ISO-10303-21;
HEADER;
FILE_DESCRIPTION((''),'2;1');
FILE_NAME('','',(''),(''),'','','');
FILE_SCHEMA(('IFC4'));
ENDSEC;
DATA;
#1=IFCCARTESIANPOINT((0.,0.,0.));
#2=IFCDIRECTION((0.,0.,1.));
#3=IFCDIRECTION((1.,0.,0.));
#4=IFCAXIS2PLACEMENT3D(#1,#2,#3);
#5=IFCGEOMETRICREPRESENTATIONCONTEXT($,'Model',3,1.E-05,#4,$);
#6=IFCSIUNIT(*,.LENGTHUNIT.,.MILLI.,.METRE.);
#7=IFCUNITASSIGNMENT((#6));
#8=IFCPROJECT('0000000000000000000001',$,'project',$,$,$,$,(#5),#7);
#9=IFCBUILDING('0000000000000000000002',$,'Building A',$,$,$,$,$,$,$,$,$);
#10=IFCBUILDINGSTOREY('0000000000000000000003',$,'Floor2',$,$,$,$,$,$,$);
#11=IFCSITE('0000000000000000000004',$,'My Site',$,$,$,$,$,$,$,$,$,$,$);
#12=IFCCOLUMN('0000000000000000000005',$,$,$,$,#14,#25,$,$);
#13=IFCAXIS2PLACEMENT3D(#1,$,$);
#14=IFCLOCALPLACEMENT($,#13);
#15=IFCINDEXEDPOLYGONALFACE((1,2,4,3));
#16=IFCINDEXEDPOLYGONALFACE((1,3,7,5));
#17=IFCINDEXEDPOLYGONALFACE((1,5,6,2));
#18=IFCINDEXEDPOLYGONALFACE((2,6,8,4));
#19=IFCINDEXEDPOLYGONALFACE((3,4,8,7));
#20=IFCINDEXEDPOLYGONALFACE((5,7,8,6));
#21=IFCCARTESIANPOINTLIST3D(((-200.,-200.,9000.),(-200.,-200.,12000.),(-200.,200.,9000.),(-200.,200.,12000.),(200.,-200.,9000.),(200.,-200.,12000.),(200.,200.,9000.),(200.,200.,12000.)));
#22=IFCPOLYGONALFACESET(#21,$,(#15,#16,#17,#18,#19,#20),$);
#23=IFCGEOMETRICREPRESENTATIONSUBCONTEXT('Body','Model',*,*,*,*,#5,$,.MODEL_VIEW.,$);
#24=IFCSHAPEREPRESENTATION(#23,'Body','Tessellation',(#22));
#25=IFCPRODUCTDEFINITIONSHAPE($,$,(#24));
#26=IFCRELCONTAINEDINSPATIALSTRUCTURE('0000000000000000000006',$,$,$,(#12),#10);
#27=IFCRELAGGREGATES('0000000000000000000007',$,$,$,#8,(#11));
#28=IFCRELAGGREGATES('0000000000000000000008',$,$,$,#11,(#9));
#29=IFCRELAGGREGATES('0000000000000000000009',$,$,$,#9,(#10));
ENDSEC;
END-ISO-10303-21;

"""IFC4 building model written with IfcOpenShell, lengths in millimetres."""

from ifc_helpers import new_model, si_unit, frame, origin_with_axes, place, context, subcontext, project, spatial, line, indexed_curve, outline, extrude, element, save


model = new_model("IFC4")

# Units and contexts
model_context = context("Model", 3, precision=1e-05, world=origin_with_axes())
body_context = subcontext(model_context, "Body", "Model", "MODEL_VIEW")
ifc_project = project(units=[si_unit("LENGTHUNIT", "METRE", prefix="MILLI")], contexts=[model_context])

# Site, building, storey
site = spatial("IfcSite", under=ifc_project, Name="My Site")
building = spatial("IfcBuilding", under=site, Name="Building A")
storey = spatial("IfcBuildingStorey", under=building, Name="Floor2")

# Column
column_placement = place(None, frame((0.0, 0.0, 9000.0), z_axis=(0.0, 0.0, 1.0), x_axis=(1.0, 0.0, 0.0)))
element("IfcColumn", 1, at=column_placement, inside=storey, context=body_context, shape_type="SweptSolid", body=[
    extrude(outline(indexed_curve([(-200.0, -200.0), (200.0, -200.0), (200.0, 200.0), (-200.0, 200.0)], segments=[line(1, 2, 3, 4, 1)])), origin_with_axes(), (0.0, 0.0, 1.0), 3000.0),
])

save(model, "model.ifc")
